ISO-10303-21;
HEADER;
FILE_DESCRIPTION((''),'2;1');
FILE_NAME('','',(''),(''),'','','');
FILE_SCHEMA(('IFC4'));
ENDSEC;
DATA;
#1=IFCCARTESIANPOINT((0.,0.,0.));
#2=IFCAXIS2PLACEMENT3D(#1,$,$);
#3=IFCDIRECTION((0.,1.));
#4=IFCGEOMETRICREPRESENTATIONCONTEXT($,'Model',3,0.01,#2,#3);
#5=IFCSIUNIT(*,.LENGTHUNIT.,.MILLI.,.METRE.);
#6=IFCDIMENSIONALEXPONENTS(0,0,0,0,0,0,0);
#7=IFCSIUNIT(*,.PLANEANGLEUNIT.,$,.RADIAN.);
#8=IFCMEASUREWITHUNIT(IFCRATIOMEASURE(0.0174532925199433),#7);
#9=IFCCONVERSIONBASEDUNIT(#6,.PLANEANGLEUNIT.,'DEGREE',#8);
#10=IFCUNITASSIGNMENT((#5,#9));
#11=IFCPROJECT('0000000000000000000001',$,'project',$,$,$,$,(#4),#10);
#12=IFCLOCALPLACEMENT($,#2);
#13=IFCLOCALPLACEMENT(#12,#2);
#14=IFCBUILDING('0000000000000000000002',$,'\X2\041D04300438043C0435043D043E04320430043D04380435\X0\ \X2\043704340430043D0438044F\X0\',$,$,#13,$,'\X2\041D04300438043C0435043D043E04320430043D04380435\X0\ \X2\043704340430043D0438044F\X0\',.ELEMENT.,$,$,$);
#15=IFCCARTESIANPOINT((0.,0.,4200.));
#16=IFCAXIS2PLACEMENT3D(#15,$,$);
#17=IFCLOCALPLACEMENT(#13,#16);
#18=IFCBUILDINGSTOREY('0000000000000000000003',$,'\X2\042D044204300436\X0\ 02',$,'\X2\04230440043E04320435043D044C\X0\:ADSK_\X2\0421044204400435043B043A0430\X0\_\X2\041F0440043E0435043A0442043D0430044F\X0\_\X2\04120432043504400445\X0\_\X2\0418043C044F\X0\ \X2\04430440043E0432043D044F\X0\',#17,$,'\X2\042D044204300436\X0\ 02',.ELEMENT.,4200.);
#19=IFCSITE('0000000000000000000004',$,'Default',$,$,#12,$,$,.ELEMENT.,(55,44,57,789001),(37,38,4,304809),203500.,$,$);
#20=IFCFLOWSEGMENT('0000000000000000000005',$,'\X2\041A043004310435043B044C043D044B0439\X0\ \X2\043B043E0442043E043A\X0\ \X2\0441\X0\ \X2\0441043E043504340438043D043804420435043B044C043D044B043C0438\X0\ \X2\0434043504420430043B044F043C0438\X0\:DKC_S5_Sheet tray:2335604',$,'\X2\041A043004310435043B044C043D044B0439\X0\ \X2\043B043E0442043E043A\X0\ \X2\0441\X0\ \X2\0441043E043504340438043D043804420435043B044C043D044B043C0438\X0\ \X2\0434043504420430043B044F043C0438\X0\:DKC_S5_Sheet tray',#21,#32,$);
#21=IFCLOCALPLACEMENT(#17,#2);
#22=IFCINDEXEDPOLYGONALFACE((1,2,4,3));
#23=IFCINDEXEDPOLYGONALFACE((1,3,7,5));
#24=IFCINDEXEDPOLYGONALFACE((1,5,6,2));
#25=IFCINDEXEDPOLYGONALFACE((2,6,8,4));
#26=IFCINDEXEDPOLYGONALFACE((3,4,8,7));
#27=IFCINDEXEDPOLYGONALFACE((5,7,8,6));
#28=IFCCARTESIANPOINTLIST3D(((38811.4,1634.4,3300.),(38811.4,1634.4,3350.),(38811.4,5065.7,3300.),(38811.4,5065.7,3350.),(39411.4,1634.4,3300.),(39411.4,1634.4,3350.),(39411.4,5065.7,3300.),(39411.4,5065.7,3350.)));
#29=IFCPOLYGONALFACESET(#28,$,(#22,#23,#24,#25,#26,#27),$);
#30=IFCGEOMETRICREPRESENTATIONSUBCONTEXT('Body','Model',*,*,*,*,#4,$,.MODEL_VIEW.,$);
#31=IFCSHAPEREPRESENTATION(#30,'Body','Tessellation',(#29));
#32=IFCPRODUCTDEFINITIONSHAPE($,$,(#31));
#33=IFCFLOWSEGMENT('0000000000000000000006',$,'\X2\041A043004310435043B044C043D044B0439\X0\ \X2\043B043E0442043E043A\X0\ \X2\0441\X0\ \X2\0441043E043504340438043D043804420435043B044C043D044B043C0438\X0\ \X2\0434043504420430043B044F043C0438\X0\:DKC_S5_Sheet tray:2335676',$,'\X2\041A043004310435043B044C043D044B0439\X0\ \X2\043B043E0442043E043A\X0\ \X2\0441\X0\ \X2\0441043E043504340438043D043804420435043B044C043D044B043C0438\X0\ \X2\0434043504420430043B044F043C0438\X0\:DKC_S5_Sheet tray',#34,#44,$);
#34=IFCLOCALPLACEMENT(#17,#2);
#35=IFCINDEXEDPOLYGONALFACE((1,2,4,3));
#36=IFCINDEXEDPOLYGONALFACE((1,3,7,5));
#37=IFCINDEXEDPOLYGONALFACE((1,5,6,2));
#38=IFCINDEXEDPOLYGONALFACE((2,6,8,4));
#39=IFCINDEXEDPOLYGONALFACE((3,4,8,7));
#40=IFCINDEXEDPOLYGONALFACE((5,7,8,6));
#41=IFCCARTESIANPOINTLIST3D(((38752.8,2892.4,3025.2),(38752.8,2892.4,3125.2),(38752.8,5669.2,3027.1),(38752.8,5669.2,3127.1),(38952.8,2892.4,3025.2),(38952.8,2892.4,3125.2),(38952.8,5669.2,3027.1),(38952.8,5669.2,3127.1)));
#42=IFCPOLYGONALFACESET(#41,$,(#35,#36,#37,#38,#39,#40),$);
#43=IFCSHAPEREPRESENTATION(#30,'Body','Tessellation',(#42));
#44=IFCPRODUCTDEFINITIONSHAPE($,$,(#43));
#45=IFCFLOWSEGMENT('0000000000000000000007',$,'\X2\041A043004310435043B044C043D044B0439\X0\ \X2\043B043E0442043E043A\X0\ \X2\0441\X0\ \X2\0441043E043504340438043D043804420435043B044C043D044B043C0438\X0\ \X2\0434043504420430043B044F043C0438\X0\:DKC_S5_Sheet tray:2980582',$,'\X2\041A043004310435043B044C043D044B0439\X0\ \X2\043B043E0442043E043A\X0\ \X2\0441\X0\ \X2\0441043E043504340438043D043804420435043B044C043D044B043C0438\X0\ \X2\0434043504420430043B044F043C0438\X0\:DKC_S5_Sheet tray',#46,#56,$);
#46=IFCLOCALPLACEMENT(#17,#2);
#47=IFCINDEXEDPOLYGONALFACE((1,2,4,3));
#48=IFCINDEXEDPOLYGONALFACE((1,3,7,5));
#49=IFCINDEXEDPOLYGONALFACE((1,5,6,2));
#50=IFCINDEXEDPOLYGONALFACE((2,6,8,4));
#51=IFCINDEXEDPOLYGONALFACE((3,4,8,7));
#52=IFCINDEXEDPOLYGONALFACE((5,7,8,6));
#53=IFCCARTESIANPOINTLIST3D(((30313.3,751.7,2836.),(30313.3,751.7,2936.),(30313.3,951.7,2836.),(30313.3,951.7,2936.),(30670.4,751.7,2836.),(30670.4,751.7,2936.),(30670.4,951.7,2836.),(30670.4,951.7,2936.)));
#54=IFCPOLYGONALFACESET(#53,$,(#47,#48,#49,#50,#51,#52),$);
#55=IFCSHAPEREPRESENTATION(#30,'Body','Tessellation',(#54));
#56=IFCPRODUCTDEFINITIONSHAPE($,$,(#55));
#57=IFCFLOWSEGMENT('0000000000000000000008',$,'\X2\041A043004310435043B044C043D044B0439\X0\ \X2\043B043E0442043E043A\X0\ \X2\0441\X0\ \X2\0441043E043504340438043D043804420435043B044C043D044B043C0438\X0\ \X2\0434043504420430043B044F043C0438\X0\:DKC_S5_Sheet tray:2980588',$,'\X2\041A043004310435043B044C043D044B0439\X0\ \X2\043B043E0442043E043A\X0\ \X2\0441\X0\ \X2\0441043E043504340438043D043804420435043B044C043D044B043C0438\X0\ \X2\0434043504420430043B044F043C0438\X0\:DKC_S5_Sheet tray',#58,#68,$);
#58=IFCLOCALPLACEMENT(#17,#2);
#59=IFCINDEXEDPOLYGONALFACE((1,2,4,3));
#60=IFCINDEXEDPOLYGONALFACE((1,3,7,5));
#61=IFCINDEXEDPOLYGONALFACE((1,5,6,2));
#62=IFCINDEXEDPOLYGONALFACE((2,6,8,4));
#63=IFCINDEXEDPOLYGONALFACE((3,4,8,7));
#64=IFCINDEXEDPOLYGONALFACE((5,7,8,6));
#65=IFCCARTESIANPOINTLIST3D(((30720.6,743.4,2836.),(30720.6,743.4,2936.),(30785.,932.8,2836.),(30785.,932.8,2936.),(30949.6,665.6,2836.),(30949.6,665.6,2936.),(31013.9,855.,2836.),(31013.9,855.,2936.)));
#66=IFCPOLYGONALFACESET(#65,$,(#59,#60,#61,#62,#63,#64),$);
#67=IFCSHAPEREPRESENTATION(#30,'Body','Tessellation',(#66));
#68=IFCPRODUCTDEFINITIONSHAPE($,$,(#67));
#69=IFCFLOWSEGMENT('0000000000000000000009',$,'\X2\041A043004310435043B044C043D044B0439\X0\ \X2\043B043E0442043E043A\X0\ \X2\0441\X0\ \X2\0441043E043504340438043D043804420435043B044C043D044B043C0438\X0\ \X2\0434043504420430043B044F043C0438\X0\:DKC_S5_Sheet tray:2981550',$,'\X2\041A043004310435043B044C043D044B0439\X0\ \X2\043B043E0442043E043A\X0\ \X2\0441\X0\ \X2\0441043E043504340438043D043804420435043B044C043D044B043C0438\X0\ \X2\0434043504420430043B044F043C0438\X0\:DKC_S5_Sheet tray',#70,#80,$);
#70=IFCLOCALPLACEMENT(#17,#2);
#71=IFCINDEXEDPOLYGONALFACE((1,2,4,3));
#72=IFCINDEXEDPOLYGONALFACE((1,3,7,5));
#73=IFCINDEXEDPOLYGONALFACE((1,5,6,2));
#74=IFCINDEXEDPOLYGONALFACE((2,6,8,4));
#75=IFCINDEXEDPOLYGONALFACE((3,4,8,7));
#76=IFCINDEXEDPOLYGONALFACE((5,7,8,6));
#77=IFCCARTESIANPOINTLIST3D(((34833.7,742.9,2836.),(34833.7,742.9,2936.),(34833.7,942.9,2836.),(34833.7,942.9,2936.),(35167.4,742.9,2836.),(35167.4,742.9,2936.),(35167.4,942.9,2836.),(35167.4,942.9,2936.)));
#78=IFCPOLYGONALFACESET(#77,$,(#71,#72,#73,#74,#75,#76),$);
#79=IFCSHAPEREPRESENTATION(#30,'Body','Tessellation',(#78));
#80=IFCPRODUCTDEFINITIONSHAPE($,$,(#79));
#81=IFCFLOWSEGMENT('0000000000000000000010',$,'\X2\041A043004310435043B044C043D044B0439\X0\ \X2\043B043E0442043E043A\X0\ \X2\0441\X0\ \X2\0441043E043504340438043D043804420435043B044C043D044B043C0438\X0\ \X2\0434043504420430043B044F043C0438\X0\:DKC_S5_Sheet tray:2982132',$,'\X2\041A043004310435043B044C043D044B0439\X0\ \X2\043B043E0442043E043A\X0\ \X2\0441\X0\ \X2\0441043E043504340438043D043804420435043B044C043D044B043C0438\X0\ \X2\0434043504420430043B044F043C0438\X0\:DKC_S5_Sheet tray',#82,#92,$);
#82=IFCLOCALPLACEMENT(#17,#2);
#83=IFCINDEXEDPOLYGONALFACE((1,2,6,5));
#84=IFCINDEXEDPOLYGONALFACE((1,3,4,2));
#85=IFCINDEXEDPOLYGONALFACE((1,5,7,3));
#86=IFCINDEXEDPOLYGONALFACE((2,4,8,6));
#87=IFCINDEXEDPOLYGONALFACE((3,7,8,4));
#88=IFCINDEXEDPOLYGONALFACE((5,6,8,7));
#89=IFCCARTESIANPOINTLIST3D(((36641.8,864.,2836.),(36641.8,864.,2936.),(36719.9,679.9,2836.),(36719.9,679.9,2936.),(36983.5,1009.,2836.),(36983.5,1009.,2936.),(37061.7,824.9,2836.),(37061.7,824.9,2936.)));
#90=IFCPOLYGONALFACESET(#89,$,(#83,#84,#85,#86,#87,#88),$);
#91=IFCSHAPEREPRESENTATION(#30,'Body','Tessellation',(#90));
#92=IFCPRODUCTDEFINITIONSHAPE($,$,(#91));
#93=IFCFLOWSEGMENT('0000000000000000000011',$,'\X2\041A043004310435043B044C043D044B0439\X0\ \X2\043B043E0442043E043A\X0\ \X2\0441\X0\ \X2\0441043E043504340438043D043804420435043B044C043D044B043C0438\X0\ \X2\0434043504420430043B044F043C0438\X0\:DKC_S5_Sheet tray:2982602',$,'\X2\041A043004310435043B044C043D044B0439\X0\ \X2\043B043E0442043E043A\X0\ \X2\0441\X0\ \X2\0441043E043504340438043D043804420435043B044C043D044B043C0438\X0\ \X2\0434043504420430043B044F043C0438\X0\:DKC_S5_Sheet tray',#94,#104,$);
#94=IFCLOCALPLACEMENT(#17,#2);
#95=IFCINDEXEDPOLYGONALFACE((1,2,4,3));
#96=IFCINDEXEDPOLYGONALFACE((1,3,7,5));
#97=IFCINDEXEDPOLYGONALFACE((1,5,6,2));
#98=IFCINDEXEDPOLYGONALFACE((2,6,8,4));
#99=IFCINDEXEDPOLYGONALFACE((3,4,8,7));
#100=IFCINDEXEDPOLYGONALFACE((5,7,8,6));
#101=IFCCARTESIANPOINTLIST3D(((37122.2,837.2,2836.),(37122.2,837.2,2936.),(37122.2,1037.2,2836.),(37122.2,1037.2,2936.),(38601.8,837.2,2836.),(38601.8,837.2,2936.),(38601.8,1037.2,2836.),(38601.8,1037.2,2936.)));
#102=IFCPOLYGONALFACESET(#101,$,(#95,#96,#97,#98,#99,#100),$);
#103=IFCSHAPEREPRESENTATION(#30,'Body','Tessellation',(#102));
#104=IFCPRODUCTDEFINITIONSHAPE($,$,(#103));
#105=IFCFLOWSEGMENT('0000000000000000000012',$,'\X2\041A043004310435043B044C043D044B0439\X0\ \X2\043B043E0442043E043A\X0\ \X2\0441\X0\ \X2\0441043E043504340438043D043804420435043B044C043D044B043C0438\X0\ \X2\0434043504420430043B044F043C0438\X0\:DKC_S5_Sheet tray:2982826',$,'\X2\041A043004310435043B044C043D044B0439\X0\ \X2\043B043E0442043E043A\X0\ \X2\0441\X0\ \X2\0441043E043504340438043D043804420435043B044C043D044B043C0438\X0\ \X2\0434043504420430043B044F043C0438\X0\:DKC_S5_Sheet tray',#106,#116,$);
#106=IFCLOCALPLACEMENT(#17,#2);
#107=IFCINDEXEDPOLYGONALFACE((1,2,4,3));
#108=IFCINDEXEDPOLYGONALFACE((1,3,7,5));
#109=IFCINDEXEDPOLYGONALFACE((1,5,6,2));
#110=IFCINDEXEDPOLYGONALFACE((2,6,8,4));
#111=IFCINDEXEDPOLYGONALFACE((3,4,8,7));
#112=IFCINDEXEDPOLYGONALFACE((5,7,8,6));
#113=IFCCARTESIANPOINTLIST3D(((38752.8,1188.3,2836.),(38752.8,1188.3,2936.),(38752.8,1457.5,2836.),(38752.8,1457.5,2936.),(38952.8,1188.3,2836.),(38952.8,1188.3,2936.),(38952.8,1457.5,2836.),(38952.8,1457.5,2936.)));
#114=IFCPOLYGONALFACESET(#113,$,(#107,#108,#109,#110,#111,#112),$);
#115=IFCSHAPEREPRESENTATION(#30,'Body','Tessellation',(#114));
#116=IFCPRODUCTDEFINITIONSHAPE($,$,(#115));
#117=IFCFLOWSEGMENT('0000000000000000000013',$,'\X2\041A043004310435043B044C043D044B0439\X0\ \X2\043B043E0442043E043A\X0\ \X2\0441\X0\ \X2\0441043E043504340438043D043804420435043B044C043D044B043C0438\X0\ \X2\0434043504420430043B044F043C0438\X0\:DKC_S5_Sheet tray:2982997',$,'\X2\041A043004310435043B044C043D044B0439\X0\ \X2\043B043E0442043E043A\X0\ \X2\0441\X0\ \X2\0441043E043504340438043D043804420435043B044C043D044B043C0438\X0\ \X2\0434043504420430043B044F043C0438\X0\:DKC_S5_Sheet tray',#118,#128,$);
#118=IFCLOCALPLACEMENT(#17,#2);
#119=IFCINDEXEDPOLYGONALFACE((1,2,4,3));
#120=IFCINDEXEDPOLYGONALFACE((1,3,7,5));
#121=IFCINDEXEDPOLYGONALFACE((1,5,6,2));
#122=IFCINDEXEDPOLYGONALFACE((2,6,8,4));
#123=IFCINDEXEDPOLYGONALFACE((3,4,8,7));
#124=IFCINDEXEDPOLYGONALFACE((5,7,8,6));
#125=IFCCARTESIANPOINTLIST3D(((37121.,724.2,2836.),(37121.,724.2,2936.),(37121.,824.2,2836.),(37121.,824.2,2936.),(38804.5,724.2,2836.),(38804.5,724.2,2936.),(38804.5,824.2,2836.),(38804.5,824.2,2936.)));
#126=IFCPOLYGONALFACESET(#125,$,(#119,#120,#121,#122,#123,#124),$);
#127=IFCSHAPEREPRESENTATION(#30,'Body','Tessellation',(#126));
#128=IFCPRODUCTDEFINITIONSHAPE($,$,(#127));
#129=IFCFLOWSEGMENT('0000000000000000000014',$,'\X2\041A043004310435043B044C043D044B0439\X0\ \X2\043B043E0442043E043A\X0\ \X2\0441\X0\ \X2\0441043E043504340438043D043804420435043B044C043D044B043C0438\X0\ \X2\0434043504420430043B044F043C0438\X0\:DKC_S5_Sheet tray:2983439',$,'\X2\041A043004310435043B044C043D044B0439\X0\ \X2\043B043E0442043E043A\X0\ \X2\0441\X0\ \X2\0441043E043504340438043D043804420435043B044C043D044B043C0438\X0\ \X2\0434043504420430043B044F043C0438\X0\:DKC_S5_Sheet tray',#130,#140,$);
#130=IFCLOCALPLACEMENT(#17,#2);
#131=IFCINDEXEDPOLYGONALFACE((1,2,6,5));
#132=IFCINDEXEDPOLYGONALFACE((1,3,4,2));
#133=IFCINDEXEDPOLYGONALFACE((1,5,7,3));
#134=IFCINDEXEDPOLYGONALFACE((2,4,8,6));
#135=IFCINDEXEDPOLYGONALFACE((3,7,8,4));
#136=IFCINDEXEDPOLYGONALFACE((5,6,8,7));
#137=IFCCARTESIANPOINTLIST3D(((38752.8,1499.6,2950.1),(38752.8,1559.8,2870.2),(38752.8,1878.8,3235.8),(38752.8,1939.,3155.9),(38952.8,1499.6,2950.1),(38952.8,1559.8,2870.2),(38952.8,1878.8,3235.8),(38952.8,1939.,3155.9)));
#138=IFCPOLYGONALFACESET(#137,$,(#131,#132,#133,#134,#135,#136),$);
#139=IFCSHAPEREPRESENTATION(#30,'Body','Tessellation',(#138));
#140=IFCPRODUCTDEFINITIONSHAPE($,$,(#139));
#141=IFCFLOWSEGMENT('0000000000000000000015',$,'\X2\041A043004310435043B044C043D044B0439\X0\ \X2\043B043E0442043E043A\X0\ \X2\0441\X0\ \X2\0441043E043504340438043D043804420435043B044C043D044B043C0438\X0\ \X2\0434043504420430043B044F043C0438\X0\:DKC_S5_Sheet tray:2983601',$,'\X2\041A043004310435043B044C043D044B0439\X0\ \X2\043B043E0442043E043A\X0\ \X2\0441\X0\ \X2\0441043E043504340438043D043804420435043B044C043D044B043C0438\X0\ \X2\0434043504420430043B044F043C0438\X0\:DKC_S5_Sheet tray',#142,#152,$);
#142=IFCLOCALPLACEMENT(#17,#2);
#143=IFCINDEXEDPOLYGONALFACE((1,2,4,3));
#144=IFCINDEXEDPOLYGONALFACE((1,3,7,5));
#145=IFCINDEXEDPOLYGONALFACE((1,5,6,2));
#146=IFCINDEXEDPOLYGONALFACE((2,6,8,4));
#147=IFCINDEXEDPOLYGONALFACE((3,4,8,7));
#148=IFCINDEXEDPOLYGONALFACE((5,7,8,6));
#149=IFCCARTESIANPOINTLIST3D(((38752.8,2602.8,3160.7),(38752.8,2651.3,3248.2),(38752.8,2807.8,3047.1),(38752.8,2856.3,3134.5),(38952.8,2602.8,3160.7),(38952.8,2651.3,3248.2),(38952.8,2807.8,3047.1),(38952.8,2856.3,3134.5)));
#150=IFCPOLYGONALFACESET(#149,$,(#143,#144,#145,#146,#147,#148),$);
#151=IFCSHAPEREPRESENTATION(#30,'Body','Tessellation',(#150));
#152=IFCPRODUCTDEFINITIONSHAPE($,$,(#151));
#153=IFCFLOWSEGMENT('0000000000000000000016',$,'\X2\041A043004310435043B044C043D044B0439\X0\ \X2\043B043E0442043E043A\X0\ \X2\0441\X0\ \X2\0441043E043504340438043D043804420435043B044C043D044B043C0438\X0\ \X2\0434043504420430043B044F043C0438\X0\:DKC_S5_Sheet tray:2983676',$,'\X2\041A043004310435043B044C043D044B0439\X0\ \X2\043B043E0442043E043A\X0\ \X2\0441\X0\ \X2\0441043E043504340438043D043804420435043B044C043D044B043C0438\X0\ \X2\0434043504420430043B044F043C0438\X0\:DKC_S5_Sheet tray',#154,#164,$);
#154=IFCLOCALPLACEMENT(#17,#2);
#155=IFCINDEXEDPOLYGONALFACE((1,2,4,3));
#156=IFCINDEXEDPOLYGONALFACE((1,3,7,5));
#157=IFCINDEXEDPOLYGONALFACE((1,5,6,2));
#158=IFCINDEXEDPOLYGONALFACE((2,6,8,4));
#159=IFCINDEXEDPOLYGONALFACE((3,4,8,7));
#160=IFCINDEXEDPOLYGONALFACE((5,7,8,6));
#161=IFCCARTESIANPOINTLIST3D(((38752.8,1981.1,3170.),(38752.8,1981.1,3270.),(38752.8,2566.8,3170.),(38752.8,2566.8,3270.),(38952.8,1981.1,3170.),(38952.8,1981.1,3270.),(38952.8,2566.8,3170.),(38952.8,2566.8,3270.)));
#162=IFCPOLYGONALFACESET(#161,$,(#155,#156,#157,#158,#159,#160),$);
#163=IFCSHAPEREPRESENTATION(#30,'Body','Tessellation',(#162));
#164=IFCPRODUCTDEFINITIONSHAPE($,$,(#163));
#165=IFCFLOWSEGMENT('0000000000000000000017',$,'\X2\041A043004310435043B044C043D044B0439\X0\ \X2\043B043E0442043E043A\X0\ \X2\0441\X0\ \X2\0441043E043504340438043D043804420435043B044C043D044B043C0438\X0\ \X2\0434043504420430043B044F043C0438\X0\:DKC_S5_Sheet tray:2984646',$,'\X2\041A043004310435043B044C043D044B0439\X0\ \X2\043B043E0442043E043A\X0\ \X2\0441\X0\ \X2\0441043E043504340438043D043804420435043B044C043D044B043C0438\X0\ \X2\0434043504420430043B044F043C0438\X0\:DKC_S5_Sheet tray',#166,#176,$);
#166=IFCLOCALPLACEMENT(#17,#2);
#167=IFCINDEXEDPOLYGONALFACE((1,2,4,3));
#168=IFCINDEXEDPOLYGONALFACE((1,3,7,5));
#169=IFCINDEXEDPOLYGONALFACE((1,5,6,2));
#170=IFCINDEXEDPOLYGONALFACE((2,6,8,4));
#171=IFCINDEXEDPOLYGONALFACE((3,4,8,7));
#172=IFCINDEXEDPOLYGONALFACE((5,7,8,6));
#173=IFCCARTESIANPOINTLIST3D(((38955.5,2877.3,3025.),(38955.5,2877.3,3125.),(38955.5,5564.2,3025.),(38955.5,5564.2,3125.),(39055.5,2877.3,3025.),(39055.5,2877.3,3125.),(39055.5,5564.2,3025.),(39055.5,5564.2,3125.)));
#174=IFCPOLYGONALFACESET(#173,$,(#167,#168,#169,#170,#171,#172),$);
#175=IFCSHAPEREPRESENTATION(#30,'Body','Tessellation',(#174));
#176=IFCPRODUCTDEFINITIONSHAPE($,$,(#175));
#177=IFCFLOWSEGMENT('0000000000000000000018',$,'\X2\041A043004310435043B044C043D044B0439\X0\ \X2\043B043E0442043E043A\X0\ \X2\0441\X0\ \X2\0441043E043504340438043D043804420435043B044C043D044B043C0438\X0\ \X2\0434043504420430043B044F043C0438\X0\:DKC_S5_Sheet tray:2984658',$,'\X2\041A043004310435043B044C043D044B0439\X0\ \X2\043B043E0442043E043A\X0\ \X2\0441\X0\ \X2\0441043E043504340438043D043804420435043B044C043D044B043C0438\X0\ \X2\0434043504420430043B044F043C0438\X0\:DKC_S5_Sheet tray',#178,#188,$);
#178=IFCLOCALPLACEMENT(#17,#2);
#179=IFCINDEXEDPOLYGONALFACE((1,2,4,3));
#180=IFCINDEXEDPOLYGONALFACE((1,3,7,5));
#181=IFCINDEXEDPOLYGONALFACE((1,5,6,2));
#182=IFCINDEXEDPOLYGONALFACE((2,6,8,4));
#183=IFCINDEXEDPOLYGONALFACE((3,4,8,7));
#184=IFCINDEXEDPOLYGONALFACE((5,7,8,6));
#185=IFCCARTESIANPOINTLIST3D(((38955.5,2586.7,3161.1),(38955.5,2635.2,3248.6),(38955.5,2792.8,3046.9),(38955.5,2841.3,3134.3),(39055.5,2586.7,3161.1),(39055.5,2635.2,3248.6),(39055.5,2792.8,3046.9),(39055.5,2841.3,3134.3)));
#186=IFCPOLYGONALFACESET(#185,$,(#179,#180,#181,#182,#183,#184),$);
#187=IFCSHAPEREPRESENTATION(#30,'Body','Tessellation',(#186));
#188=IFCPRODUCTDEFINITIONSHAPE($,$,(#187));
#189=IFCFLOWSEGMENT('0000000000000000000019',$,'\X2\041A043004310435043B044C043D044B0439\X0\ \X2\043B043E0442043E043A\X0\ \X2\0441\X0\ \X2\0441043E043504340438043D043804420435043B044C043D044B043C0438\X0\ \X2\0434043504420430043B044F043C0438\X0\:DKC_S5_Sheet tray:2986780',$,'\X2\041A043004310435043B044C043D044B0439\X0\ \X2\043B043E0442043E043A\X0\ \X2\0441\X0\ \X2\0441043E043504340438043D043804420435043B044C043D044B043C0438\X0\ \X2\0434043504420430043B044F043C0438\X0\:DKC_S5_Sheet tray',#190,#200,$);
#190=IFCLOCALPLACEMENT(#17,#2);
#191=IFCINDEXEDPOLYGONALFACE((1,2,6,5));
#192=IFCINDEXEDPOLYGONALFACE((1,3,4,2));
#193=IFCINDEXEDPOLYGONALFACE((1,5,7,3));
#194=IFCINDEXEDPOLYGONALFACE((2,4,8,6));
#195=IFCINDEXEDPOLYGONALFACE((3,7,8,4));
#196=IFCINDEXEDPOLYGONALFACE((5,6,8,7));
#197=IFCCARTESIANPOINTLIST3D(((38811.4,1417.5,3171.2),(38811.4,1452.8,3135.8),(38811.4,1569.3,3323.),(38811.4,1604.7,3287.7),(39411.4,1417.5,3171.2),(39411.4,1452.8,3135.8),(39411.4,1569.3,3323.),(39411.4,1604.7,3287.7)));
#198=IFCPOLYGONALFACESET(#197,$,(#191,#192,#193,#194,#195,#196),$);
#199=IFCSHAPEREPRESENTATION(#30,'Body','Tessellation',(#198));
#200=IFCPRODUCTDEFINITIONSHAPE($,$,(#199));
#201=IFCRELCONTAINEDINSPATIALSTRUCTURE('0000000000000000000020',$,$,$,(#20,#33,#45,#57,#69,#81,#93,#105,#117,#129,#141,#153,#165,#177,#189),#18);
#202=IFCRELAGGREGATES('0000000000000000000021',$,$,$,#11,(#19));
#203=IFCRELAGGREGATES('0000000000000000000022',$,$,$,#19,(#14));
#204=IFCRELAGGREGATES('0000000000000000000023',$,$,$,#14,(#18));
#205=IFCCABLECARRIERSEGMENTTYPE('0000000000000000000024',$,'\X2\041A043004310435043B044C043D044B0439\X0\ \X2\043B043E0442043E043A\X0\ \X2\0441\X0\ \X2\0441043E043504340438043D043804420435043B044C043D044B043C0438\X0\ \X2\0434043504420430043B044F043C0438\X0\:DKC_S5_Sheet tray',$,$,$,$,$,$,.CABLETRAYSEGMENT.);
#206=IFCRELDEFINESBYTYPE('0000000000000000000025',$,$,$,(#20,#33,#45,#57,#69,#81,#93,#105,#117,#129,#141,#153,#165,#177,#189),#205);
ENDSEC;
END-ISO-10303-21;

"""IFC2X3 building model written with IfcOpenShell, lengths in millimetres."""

from ifc_helpers import new_model, entity, si_unit, converted_unit, direction, frame, frame_2d, origin, origin_2d_with_axis, place, context, subcontext, project, spatial, rectangle, extrude, type_object, element, save


model = new_model("IFC2X3")

# Units and contexts
model_context = context("Model", 3, precision=0.01, world=origin(), true_north=direction((0.0, 1.0)))
body_context = subcontext(model_context, "Body", "Model", "MODEL_VIEW")
ifc_project = project(units=[si_unit("LENGTHUNIT", "METRE", prefix="MILLI"), converted_unit("PLANEANGLEUNIT", "DEGREE", entity("IfcRatioMeasure", 0.0174532925199433), si_unit("PLANEANGLEUNIT", "RADIAN"), dimensions=[0, 0, 0, 0, 0, 0, 0])], contexts=[model_context])

# Site, building, storey
site_placement = place(None, origin())
site = spatial("IfcSite", under=ifc_project, at=site_placement, Name="Default", CompositionType="ELEMENT", RefLatitude=(55, 44, 57, 789001), RefLongitude=(37, 38, 4, 304809), RefElevation=203500.0)
building_placement = place(site_placement, origin())
building = spatial("IfcBuilding", under=site, at=building_placement, Name="Наименование здания", LongName="Наименование здания", CompositionType="ELEMENT")
storey_placement = place(building_placement, frame((0.0, 0.0, 4200.0)))
storey = spatial("IfcBuildingStorey", under=building, at=storey_placement, Name="Этаж 02", ObjectType="Уровень:ADSK_Стрелка_Проектная_Вверх_Имя уровня", LongName="Этаж 02", CompositionType="ELEMENT", Elevation=4200.0)

# Flow segments
cable_carrier_segment_type = type_object("IfcCableCarrierSegmentType", Name="Кабельный лоток с соединительными деталями:DKC_S5_Sheet tray", PredefinedType="CABLETRAYSEGMENT")
flow_segment_1_placement = place(storey_placement, frame((38811.4, 1634.4, 3300.0)))
element("IfcFlowSegment", 1, at=flow_segment_1_placement, inside=storey, type_object=cable_carrier_segment_type, Name="Кабельный лоток с соединительными деталями:DKC_S5_Sheet tray:2335604", ObjectType="Кабельный лоток с соединительными деталями:DKC_S5_Sheet tray", context=body_context, shape_type="SweptSolid", body=[
    extrude(rectangle(XDim=3431.2, YDim=600.0, at=origin_2d_with_axis()), frame((300.0, 1715.6, 0.0), z_axis=(0.0, 0.0, 1.0), x_axis=(0.0, -1.0, 0.0)), (0.0, 0.0, 1.0), 50.0),
])
flow_segment_2_placement = place(storey_placement, frame((38752.8, 2892.3, 3025.2)))
element("IfcFlowSegment", 2, at=flow_segment_2_placement, inside=storey, type_object=cable_carrier_segment_type, Name="Кабельный лоток с соединительными деталями:DKC_S5_Sheet tray:2335676", ObjectType="Кабельный лоток с соединительными деталями:DKC_S5_Sheet tray", context=body_context, shape_type="SweptSolid", body=[
    extrude(rectangle(XDim=2776.8, YDim=200.0, at=origin_2d_with_axis()), frame((100.0, 1388.5, 1.0), z_axis=(0.0, -0.000692, 1.0), x_axis=(0.0, -1.0, -0.000692)), (0.0, 0.0, 1.0), 100.0),
])
flow_segment_3_placement = place(storey_placement, frame((30313.3, 751.7, 2836.0)))
element("IfcFlowSegment", 3, at=flow_segment_3_placement, inside=storey, type_object=cable_carrier_segment_type, Name="Кабельный лоток с соединительными деталями:DKC_S5_Sheet tray:2980582", ObjectType="Кабельный лоток с соединительными деталями:DKC_S5_Sheet tray", context=body_context, shape_type="SweptSolid", body=[
    extrude(rectangle(XDim=357.1, YDim=200.0, at=origin_2d_with_axis()), frame((178.5, 100.0, 0.0)), (0.0, 0.0, 1.0), 100.0),
])
flow_segment_4_placement = place(storey_placement, frame((30720.6, 665.6, 2836.0)))
element("IfcFlowSegment", 4, at=flow_segment_4_placement, inside=storey, type_object=cable_carrier_segment_type, Name="Кабельный лоток с соединительными деталями:DKC_S5_Sheet tray:2980588", ObjectType="Кабельный лоток с соединительными деталями:DKC_S5_Sheet tray", context=body_context, shape_type="SweptSolid", body=[
    extrude(rectangle(XDim=241.8, YDim=200.0, at=origin_2d_with_axis()), frame((146.6, 133.6, 0.0), z_axis=(0.0, 0.0, 1.0), x_axis=(0.946792, -0.321847, 0.0)), (0.0, 0.0, 1.0), 100.0),
])
flow_segment_5_placement = place(storey_placement, frame((34833.7, 742.9, 2836.0)))
element("IfcFlowSegment", 5, at=flow_segment_5_placement, inside=storey, type_object=cable_carrier_segment_type, Name="Кабельный лоток с соединительными деталями:DKC_S5_Sheet tray:2981550", ObjectType="Кабельный лоток с соединительными деталями:DKC_S5_Sheet tray", context=body_context, shape_type="SweptSolid", body=[
    extrude(rectangle(XDim=333.7, YDim=200.0, at=origin_2d_with_axis()), frame((166.8, 100.0, 0.0)), (0.0, 0.0, 1.0), 100.0),
])
flow_segment_6_placement = place(storey_placement, frame((36641.8, 679.9, 2836.0)))
element("IfcFlowSegment", 6, at=flow_segment_6_placement, inside=storey, type_object=cable_carrier_segment_type, Name="Кабельный лоток с соединительными деталями:DKC_S5_Sheet tray:2982132", ObjectType="Кабельный лоток с соединительными деталями:DKC_S5_Sheet tray", context=body_context, shape_type="SweptSolid", body=[
    extrude(rectangle(XDim=371.3, YDim=200.0, at=origin_2d_with_axis()), frame((209.9, 164.6, 0.0), z_axis=(0.0, 0.0, 1.0), x_axis=(0.920505, 0.390731, 0.0)), (0.0, 0.0, 1.0), 100.0),
])
flow_segment_7_placement = place(storey_placement, frame((37122.2, 837.2, 2836.0)))
element("IfcFlowSegment", 7, at=flow_segment_7_placement, inside=storey, type_object=cable_carrier_segment_type, Name="Кабельный лоток с соединительными деталями:DKC_S5_Sheet tray:2982602", ObjectType="Кабельный лоток с соединительными деталями:DKC_S5_Sheet tray", context=body_context, shape_type="SweptSolid", body=[
    extrude(rectangle(XDim=1479.6, YDim=200.0, at=origin_2d_with_axis()), frame((739.8, 100.0, 0.0)), (0.0, 0.0, 1.0), 100.0),
])
flow_segment_8_placement = place(storey_placement, frame((38752.8, 1188.2, 2836.0)))
element("IfcFlowSegment", 8, at=flow_segment_8_placement, inside=storey, type_object=cable_carrier_segment_type, Name="Кабельный лоток с соединительными деталями:DKC_S5_Sheet tray:2982826", ObjectType="Кабельный лоток с соединительными деталями:DKC_S5_Sheet tray", context=body_context, shape_type="SweptSolid", body=[
    extrude(rectangle(XDim=269.3, YDim=200.0, at=origin_2d_with_axis()), frame((100.0, 134.7, 0.0), z_axis=(0.0, 0.0, 1.0), x_axis=(0.0, 1.0, 0.0)), (0.0, 0.0, 1.0), 100.0),
])
flow_segment_9_placement = place(storey_placement, frame((37121.0, 724.2, 2836.0)))
element("IfcFlowSegment", 9, at=flow_segment_9_placement, inside=storey, type_object=cable_carrier_segment_type, Name="Кабельный лоток с соединительными деталями:DKC_S5_Sheet tray:2982997", ObjectType="Кабельный лоток с соединительными деталями:DKC_S5_Sheet tray", context=body_context, shape_type="SweptSolid", body=[
    extrude(rectangle(XDim=1683.5, YDim=100.0, at=origin_2d_with_axis()), frame((841.8, 50.0, 0.0)), (0.0, 0.0, 1.0), 100.0),
])
flow_segment_10_placement = place(storey_placement, frame((38752.8, 1499.7, 2870.2)))
element("IfcFlowSegment", 10, at=flow_segment_10_placement, inside=storey, type_object=cable_carrier_segment_type, Name="Кабельный лоток с соединительными деталями:DKC_S5_Sheet tray:2983439", ObjectType="Кабельный лоток с соединительными деталями:DKC_S5_Sheet tray", context=body_context, shape_type="SweptSolid", body=[
    extrude(rectangle(XDim=100.0, YDim=474.7, at=frame_2d((0.0, 0.0), x_axis=(0.0, 1.0))), frame((0.0, 219.7, 182.8), z_axis=(1.0, 0.0, 0.0), x_axis=(0.0, 0.798636, 0.601815)), (0.0, 0.0, 1.0), 200.0),
])
flow_segment_11_placement = place(storey_placement, frame((38752.8, 2602.8, 3047.1)))
element("IfcFlowSegment", 11, at=flow_segment_11_placement, inside=storey, type_object=cable_carrier_segment_type, Name="Кабельный лоток с соединительными деталями:DKC_S5_Sheet tray:2983601", ObjectType="Кабельный лоток с соединительными деталями:DKC_S5_Sheet tray", context=body_context, shape_type="SweptSolid", body=[
    extrude(rectangle(XDim=100.0, YDim=234.4, at=frame_2d((0.0, 0.0), x_axis=(0.0, 1.0))), frame((0.0, 126.7, 100.5), z_axis=(1.0, 0.0, 0.0), x_axis=(0.0, -0.87462, 0.48481)), (0.0, 0.0, 1.0), 200.0),
])
flow_segment_12_placement = place(storey_placement, frame((38752.8, 1981.1, 3170.0)))
element("IfcFlowSegment", 12, at=flow_segment_12_placement, inside=storey, type_object=cable_carrier_segment_type, Name="Кабельный лоток с соединительными деталями:DKC_S5_Sheet tray:2983676", ObjectType="Кабельный лоток с соединительными деталями:DKC_S5_Sheet tray", context=body_context, shape_type="SweptSolid", body=[
    extrude(rectangle(XDim=585.7, YDim=200.0, at=origin_2d_with_axis()), frame((100.0, 292.9, 0.0), z_axis=(0.0, 0.0, 1.0), x_axis=(0.0, -1.0, 0.0)), (0.0, 0.0, 1.0), 100.0),
])
flow_segment_13_placement = place(storey_placement, frame((38955.5, 2877.3, 3025.0)))
element("IfcFlowSegment", 13, at=flow_segment_13_placement, inside=storey, type_object=cable_carrier_segment_type, Name="Кабельный лоток с соединительными деталями:DKC_S5_Sheet tray:2984646", ObjectType="Кабельный лоток с соединительными деталями:DKC_S5_Sheet tray", context=body_context, shape_type="SweptSolid", body=[
    extrude(rectangle(XDim=2686.8, YDim=100.0, at=origin_2d_with_axis()), frame((50.0, 1343.4, 0.0), z_axis=(0.0, 0.0, 1.0), x_axis=(0.0, -1.0, 0.0)), (0.0, 0.0, 1.0), 100.0),
])
flow_segment_14_placement = place(storey_placement, frame((38955.5, 2586.7, 3046.9)))
element("IfcFlowSegment", 14, at=flow_segment_14_placement, inside=storey, type_object=cable_carrier_segment_type, Name="Кабельный лоток с соединительными деталями:DKC_S5_Sheet tray:2984658", ObjectType="Кабельный лоток с соединительными деталями:DKC_S5_Sheet tray", context=body_context, shape_type="SweptSolid", body=[
    extrude(rectangle(XDim=100.0, YDim=100.0, at=origin_2d_with_axis()), frame((50.0, 24.2, 158.0), z_axis=(0.0, 0.87462, -0.48481), x_axis=(0.0, 0.48481, 0.87462)), (0.0, 0.0, 1.0), 235.7),
])
flow_segment_15_placement = place(storey_placement, frame((38811.4, 1417.5, 3135.8)))
element("IfcFlowSegment", 15, at=flow_segment_15_placement, inside=storey, type_object=cable_carrier_segment_type, Name="Кабельный лоток с соединительными деталями:DKC_S5_Sheet tray:2986780", ObjectType="Кабельный лоток с соединительными деталями:DKC_S5_Sheet tray", context=body_context, shape_type="SweptSolid", body=[
    extrude(rectangle(XDim=50.0, YDim=214.8, at=frame_2d((0.0, 0.0), x_axis=(0.0, 1.0))), frame((0.0, 93.6, 93.6), z_axis=(1.0, 0.0, 0.0), x_axis=(0.0, -0.707107, -0.707107)), (0.0, 0.0, 1.0), 600.0),
])

save(model, "model.ifc")
